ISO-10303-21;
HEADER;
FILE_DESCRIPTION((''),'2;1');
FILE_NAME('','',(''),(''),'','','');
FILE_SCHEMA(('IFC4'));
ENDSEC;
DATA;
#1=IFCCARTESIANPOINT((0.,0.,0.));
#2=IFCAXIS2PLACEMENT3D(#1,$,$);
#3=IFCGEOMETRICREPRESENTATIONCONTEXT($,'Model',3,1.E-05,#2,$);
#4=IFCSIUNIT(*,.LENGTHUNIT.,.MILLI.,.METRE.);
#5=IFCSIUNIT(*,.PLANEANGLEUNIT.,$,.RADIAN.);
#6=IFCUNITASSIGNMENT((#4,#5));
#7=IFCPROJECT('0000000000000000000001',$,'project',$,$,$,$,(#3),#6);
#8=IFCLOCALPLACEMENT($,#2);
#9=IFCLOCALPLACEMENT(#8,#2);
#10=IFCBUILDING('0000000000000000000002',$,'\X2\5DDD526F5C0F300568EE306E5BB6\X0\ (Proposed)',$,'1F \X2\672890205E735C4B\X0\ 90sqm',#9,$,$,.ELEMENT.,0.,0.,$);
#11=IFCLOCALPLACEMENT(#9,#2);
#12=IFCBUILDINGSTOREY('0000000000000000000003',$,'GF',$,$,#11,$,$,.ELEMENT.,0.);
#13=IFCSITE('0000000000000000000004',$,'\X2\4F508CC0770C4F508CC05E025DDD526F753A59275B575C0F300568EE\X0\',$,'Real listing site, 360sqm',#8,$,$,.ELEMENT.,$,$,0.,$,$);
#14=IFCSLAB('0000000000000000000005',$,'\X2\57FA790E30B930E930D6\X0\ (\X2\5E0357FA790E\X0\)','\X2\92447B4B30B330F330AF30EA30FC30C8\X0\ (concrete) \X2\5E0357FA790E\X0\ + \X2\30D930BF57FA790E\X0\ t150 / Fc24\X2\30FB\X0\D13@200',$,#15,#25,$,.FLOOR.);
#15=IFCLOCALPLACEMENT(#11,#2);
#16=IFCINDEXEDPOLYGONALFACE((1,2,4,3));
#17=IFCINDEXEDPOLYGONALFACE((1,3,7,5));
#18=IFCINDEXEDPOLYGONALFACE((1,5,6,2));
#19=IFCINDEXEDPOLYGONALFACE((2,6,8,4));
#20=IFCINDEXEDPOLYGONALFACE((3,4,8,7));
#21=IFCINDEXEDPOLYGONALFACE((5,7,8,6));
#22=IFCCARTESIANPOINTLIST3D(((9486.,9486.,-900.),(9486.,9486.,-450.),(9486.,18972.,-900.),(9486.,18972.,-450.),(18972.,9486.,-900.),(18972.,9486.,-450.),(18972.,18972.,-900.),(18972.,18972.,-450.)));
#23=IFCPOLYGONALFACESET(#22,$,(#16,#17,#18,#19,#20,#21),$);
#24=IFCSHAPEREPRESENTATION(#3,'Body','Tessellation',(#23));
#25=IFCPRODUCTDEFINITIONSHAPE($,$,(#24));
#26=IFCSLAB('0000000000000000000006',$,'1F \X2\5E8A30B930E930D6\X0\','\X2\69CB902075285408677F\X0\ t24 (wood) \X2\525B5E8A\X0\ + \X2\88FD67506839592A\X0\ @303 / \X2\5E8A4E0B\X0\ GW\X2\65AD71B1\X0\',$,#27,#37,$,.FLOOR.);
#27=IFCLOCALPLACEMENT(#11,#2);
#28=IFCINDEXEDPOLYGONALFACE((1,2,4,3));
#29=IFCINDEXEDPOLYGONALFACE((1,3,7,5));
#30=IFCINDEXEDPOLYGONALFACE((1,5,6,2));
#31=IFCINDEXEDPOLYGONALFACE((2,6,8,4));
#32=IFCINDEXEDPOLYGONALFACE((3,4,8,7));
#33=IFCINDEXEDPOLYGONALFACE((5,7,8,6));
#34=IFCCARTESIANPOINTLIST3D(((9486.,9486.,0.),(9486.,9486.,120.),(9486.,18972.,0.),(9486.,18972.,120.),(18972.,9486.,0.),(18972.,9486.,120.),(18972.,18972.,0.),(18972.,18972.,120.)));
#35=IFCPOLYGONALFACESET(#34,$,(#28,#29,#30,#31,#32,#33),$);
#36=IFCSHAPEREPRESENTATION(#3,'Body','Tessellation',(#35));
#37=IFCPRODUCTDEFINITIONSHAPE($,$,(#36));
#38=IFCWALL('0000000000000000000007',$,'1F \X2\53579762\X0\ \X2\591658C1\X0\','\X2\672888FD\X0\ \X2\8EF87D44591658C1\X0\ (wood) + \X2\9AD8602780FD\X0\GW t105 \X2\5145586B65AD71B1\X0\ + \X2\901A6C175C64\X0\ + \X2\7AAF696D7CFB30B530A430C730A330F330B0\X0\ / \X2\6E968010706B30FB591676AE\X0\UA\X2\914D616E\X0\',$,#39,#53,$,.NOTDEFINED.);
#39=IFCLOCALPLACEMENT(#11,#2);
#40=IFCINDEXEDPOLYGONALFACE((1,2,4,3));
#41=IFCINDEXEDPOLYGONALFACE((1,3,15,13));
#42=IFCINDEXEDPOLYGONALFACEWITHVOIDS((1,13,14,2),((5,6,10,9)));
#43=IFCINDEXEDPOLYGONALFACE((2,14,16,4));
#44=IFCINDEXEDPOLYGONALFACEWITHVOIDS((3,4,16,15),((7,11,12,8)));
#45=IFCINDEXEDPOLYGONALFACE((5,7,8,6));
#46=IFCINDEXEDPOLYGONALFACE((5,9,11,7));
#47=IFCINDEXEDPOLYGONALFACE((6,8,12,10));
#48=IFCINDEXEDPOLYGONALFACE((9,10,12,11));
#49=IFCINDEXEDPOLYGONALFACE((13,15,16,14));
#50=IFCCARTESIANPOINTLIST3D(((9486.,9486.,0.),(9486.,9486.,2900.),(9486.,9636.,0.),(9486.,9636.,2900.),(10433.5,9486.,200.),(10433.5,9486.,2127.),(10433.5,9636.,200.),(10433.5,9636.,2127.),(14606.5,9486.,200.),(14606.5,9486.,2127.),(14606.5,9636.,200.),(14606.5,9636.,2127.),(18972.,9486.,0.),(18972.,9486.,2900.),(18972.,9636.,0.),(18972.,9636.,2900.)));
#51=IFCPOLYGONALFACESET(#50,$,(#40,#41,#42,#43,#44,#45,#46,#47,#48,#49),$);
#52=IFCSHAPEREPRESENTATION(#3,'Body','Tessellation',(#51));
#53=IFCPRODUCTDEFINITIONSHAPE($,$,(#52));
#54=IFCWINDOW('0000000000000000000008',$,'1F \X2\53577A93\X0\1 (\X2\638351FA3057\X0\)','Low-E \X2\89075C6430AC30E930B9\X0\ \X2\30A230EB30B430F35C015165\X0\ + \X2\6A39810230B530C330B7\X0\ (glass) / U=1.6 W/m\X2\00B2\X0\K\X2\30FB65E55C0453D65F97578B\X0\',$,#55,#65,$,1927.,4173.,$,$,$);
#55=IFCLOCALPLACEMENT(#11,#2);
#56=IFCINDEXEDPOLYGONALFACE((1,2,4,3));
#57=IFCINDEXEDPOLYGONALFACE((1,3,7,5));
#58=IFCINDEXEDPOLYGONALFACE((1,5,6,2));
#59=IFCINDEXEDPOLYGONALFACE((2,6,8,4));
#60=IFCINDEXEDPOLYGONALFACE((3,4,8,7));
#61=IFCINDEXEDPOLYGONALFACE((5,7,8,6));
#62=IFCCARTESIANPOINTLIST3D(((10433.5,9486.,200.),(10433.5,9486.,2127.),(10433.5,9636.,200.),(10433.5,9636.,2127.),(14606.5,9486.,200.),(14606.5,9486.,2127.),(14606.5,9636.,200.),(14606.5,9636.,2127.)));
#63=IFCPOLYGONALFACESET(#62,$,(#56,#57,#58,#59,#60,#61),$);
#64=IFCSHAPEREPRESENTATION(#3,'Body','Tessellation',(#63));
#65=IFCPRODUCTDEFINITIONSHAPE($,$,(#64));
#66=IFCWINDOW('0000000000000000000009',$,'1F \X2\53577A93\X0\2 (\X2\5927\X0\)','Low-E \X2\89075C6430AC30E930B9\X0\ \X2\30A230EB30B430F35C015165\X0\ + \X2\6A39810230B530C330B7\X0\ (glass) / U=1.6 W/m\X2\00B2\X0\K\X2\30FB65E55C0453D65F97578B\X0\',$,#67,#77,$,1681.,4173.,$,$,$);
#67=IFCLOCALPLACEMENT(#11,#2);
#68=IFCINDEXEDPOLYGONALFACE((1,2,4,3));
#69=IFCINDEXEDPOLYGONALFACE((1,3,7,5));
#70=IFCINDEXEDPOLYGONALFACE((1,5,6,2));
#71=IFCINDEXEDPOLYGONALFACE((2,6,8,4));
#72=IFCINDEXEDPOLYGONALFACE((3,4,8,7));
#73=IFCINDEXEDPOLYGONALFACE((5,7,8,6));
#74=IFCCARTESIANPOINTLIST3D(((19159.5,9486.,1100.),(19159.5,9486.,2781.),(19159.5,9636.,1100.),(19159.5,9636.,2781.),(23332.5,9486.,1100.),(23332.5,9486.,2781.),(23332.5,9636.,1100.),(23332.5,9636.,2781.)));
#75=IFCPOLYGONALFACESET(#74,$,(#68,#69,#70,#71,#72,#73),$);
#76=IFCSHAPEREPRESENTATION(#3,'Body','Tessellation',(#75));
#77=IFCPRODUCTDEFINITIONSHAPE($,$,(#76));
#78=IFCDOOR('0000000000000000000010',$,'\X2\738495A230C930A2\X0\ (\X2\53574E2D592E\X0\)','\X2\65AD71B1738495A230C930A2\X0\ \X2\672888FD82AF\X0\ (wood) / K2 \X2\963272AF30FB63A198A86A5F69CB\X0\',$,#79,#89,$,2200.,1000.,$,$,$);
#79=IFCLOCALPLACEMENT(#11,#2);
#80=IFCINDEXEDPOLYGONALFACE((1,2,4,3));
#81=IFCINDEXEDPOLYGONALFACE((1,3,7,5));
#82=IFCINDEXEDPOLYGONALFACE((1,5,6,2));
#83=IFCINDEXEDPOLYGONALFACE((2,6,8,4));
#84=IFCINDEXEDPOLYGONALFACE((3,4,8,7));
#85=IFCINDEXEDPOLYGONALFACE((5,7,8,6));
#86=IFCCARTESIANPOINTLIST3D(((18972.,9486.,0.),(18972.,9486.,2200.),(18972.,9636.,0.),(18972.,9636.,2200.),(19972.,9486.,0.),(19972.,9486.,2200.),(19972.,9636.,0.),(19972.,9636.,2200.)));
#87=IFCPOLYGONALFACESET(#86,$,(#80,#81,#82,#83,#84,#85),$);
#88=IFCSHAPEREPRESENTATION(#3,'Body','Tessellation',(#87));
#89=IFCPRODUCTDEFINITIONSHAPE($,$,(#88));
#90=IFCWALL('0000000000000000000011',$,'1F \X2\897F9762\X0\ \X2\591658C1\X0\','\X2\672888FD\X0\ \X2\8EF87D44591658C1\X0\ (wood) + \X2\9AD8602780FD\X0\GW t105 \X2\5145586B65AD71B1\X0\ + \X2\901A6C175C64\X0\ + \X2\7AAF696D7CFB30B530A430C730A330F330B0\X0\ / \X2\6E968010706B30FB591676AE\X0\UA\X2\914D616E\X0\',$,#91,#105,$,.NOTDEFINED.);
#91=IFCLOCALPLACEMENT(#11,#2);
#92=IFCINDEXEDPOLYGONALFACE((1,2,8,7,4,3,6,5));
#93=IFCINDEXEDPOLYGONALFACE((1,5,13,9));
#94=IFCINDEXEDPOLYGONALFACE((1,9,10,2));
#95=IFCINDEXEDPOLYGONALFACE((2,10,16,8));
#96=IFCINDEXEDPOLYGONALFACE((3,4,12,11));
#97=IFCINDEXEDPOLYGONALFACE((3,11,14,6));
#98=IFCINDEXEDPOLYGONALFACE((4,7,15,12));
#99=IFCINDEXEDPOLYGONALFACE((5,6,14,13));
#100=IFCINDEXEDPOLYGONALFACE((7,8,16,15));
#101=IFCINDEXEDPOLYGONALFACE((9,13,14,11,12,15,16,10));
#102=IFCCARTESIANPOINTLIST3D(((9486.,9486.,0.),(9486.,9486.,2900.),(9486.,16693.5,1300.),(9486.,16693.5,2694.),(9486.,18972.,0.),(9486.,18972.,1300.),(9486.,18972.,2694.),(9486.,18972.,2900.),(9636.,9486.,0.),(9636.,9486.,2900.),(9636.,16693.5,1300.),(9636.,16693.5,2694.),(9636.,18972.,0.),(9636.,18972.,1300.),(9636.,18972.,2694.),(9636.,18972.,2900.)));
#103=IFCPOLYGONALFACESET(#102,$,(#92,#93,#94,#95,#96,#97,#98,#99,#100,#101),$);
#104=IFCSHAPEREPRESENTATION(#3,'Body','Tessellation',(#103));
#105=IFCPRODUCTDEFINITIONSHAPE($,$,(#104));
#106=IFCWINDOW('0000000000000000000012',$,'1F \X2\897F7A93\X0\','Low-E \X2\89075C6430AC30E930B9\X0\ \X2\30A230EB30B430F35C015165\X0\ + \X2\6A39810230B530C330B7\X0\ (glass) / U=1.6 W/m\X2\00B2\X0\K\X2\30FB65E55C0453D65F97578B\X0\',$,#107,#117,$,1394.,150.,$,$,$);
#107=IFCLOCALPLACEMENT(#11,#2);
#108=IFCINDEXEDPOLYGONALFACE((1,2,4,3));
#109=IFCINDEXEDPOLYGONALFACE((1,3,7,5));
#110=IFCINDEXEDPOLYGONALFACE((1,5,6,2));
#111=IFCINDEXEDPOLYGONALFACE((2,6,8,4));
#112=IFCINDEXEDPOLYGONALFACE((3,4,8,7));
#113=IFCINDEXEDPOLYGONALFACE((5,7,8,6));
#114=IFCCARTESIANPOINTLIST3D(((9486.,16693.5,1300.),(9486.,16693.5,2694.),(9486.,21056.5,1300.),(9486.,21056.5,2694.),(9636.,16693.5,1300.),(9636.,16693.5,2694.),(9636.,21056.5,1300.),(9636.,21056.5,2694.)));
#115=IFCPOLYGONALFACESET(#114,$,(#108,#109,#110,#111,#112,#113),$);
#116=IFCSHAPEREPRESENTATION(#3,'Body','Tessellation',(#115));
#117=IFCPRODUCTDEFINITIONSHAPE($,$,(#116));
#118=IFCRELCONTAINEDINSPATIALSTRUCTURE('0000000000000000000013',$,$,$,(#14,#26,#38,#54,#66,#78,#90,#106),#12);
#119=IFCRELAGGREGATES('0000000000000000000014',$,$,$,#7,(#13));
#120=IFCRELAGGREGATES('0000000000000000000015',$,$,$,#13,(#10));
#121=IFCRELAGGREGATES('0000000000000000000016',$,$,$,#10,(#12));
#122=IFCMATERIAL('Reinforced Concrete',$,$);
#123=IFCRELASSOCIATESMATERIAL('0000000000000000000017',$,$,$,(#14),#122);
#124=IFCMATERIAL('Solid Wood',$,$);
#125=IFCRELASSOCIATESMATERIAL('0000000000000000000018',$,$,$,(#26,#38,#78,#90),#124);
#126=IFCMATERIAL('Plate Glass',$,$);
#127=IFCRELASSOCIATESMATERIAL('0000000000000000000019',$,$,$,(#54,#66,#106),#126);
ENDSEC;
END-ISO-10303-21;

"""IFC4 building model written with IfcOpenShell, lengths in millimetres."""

from ifc_helpers import new_model, si_unit, frame, frame_2d, origin, place, context, project, spatial, rectangle, extrude, material, element, fill, save


model = new_model("IFC4")

# Units and contexts
model_context = context("Model", 3, precision=1e-05, world=origin())
ifc_project = project(units=[si_unit("LENGTHUNIT", "METRE", prefix="MILLI"), si_unit("PLANEANGLEUNIT", "RADIAN")], contexts=[model_context])

# Site, building, storey
site_placement = place(None, origin())
site = spatial("IfcSite", under=ifc_project, at=site_placement, Name="佐賀県佐賀市川副町大字小々森", ObjectType="Real listing site, 360sqm", CompositionType="ELEMENT", RefElevation=0.0)
building_placement = place(site_placement, origin())
building = spatial("IfcBuilding", under=site, at=building_placement, Name="川副小々森の家 (Proposed)", ObjectType="1F 木造平屋 90sqm", CompositionType="ELEMENT", ElevationOfRefHeight=0.0, ElevationOfTerrain=0.0)
storey_placement = place(building_placement, origin())
storey = spatial("IfcBuildingStorey", under=building, at=storey_placement, Name="GF", CompositionType="ELEMENT", Elevation=0.0)

# Slabs
ifc_material_1 = material(Name="Reinforced Concrete")
slab_1_placement = place(storey_placement, frame((4743.0, 4743.0, -450.0)))
element("IfcSlab", 1, at=slab_1_placement, inside=storey, material=ifc_material_1, Name="基礎スラブ (布基礎)", Description="鉄筋コンクリート (concrete) 布基礎 + ベタ基礎 t150 / Fc24・D13@200", PredefinedType="FLOOR", context=model_context, shape_type="SweptSolid", body=[
    extrude(rectangle(XDim=9486.0, YDim=9486.0, at=frame_2d((4743.0, 4743.0))), frame((4743.0, 4743.0, -450.0)), (0.0, 0.0, 1.0), 450.0),
])
ifc_material_2 = material(Name="Solid Wood")
slab_2_placement = place(storey_placement, frame((4743.0, 4743.0, 0.0)))
element("IfcSlab", 2, at=slab_2_placement, inside=storey, material=ifc_material_2, Name="1F 床スラブ", Description="構造用合板 t24 (wood) 剛床 + 製材根太 @303 / 床下 GW断熱", PredefinedType="FLOOR", context=model_context, shape_type="SweptSolid", body=[
    extrude(rectangle(XDim=9486.0, YDim=9486.0, at=frame_2d((4743.0, 4743.0))), frame((4743.0, 4743.0, 0.0)), (0.0, 0.0, 1.0), 120.0),
])

# Wall, openings, windows, door
wall_1_placement = place(storey_placement, frame((4743.0, 4743.0, 0.0)))
wall_1 = element("IfcWall", 3, at=wall_1_placement, inside=storey, material=ifc_material_2, Name="1F 南面 外壁", Description="木製 軸組外壁 (wood) + 高性能GW t105 充填断熱 + 通気層 + 窯業系サイディング / 準耐火・外皮UA配慮", PredefinedType="NOTDEFINED", context=model_context, shape_type="SweptSolid", body=[
    extrude(rectangle(XDim=9486.0, YDim=150.0, at=frame_2d((4743.0, 75.0))), frame((4743.0, 4743.0, 0.0)), (0.0, 0.0, 1.0), 2900.0),
])
opening_1_placement = place(storey_placement, frame((5217.0, 4743.0, 100.0)))
opening_1 = element("IfcOpeningElement", 4, at=opening_1_placement, cuts=wall_1, PredefinedType="NOTDEFINED", context=model_context, shape_type="SweptSolid", body=[
    extrude(rectangle(XDim=4173.0, YDim=150.0, at=frame_2d((2086.0, 75.0))), frame((5217.0, 4743.0, 100.0)), (0.0, 0.0, 1.0), 1927.0),
])
opening_2_placement = place(storey_placement, frame((9580.0, 4743.0, 550.0)))
opening_2 = element("IfcOpeningElement", 5, at=opening_2_placement, cuts=wall_1, PredefinedType="NOTDEFINED", context=model_context, shape_type="SweptSolid", body=[
    extrude(rectangle(XDim=4173.0, YDim=150.0, at=frame_2d((2086.0, 75.0))), frame((9580.0, 4743.0, 550.0)), (0.0, 0.0, 1.0), 1681.0),
])
opening_3_placement = place(storey_placement, frame((9486.0, 4743.0, 0.0)))
opening_3 = element("IfcOpeningElement", 6, at=opening_3_placement, cuts=wall_1, PredefinedType="NOTDEFINED", context=model_context, shape_type="SweptSolid", body=[
    extrude(rectangle(XDim=1000.0, YDim=150.0, at=frame_2d((500.0, 75.0))), frame((9486.0, 4743.0, 0.0)), (0.0, 0.0, 1.0), 2200.0),
])
ifc_material_3 = material(Name="Plate Glass")
window_1_placement = place(storey_placement, frame((5217.0, 4743.0, 100.0)))
window_1 = element("IfcWindow", 7, at=window_1_placement, inside=storey, material=ifc_material_3, Name="1F 南窓1 (掃出し)", Description="Low-E 複層ガラス アルゴン封入 + 樹脂サッシ (glass) / U=1.6 W/m²K・日射取得型", OverallHeight=1927.0, OverallWidth=4173.0, context=model_context, shape_type="SweptSolid", body=[
    extrude(rectangle(XDim=4173.0, YDim=150.0, at=frame_2d((2086.0, 75.0))), frame((5217.0, 4743.0, 100.0)), (0.0, 0.0, 1.0), 1927.0),
])
fill(opening_1, window_1)
window_2_placement = place(storey_placement, frame((9580.0, 4743.0, 550.0)))
window_2 = element("IfcWindow", 8, at=window_2_placement, inside=storey, material=ifc_material_3, Name="1F 南窓2 (大)", Description="Low-E 複層ガラス アルゴン封入 + 樹脂サッシ (glass) / U=1.6 W/m²K・日射取得型", OverallHeight=1681.0, OverallWidth=4173.0, context=model_context, shape_type="SweptSolid", body=[
    extrude(rectangle(XDim=4173.0, YDim=150.0, at=frame_2d((2086.0, 75.0))), frame((9580.0, 4743.0, 550.0)), (0.0, 0.0, 1.0), 1681.0),
])
fill(opening_2, window_2)
door_placement = place(storey_placement, frame((9486.0, 4743.0, 0.0)))
door = element("IfcDoor", 9, at=door_placement, inside=storey, material=ifc_material_2, Name="玄関ドア (南中央)", Description="断熱玄関ドア 木製芯 (wood) / K2 防犯・採風機構", OverallHeight=2200.0, OverallWidth=1000.0, context=model_context, shape_type="SweptSolid", body=[
    extrude(rectangle(XDim=1000.0, YDim=150.0, at=frame_2d((500.0, 75.0))), frame((9486.0, 4743.0, 0.0)), (0.0, 0.0, 1.0), 2200.0),
])
fill(opening_3, door)

# Wall, opening, window
wall_2_placement = place(storey_placement, frame((4743.0, 4743.0, 0.0)))
wall_2 = element("IfcWall", 10, at=wall_2_placement, inside=storey, material=ifc_material_2, Name="1F 西面 外壁", Description="木製 軸組外壁 (wood) + 高性能GW t105 充填断熱 + 通気層 + 窯業系サイディング / 準耐火・外皮UA配慮", PredefinedType="NOTDEFINED", context=model_context, shape_type="SweptSolid", body=[
    extrude(rectangle(XDim=150.0, YDim=9486.0, at=frame_2d((75.0, 4743.0))), frame((4743.0, 4743.0, 0.0)), (0.0, 0.0, 1.0), 2900.0),
])
opening_4_placement = place(storey_placement, frame((4743.0, 8347.0, 650.0)))
opening_4 = element("IfcOpeningElement", 11, at=opening_4_placement, cuts=wall_2, PredefinedType="NOTDEFINED", context=model_context, shape_type="SweptSolid", body=[
    extrude(rectangle(XDim=150.0, YDim=4363.0, at=frame_2d((75.0, 2181.0))), frame((4743.0, 8347.0, 650.0)), (0.0, 0.0, 1.0), 1394.0),
])
window_3_placement = place(storey_placement, frame((4743.0, 8347.0, 650.0)))
window_3 = element("IfcWindow", 12, at=window_3_placement, inside=storey, material=ifc_material_3, Name="1F 西窓", Description="Low-E 複層ガラス アルゴン封入 + 樹脂サッシ (glass) / U=1.6 W/m²K・日射取得型", OverallHeight=1394.0, OverallWidth=150.0, context=model_context, shape_type="SweptSolid", body=[
    extrude(rectangle(XDim=150.0, YDim=4363.0, at=frame_2d((75.0, 2181.0))), frame((4743.0, 8347.0, 650.0)), (0.0, 0.0, 1.0), 1394.0),
])
fill(opening_4, window_3)

save(model, "model.ifc")
